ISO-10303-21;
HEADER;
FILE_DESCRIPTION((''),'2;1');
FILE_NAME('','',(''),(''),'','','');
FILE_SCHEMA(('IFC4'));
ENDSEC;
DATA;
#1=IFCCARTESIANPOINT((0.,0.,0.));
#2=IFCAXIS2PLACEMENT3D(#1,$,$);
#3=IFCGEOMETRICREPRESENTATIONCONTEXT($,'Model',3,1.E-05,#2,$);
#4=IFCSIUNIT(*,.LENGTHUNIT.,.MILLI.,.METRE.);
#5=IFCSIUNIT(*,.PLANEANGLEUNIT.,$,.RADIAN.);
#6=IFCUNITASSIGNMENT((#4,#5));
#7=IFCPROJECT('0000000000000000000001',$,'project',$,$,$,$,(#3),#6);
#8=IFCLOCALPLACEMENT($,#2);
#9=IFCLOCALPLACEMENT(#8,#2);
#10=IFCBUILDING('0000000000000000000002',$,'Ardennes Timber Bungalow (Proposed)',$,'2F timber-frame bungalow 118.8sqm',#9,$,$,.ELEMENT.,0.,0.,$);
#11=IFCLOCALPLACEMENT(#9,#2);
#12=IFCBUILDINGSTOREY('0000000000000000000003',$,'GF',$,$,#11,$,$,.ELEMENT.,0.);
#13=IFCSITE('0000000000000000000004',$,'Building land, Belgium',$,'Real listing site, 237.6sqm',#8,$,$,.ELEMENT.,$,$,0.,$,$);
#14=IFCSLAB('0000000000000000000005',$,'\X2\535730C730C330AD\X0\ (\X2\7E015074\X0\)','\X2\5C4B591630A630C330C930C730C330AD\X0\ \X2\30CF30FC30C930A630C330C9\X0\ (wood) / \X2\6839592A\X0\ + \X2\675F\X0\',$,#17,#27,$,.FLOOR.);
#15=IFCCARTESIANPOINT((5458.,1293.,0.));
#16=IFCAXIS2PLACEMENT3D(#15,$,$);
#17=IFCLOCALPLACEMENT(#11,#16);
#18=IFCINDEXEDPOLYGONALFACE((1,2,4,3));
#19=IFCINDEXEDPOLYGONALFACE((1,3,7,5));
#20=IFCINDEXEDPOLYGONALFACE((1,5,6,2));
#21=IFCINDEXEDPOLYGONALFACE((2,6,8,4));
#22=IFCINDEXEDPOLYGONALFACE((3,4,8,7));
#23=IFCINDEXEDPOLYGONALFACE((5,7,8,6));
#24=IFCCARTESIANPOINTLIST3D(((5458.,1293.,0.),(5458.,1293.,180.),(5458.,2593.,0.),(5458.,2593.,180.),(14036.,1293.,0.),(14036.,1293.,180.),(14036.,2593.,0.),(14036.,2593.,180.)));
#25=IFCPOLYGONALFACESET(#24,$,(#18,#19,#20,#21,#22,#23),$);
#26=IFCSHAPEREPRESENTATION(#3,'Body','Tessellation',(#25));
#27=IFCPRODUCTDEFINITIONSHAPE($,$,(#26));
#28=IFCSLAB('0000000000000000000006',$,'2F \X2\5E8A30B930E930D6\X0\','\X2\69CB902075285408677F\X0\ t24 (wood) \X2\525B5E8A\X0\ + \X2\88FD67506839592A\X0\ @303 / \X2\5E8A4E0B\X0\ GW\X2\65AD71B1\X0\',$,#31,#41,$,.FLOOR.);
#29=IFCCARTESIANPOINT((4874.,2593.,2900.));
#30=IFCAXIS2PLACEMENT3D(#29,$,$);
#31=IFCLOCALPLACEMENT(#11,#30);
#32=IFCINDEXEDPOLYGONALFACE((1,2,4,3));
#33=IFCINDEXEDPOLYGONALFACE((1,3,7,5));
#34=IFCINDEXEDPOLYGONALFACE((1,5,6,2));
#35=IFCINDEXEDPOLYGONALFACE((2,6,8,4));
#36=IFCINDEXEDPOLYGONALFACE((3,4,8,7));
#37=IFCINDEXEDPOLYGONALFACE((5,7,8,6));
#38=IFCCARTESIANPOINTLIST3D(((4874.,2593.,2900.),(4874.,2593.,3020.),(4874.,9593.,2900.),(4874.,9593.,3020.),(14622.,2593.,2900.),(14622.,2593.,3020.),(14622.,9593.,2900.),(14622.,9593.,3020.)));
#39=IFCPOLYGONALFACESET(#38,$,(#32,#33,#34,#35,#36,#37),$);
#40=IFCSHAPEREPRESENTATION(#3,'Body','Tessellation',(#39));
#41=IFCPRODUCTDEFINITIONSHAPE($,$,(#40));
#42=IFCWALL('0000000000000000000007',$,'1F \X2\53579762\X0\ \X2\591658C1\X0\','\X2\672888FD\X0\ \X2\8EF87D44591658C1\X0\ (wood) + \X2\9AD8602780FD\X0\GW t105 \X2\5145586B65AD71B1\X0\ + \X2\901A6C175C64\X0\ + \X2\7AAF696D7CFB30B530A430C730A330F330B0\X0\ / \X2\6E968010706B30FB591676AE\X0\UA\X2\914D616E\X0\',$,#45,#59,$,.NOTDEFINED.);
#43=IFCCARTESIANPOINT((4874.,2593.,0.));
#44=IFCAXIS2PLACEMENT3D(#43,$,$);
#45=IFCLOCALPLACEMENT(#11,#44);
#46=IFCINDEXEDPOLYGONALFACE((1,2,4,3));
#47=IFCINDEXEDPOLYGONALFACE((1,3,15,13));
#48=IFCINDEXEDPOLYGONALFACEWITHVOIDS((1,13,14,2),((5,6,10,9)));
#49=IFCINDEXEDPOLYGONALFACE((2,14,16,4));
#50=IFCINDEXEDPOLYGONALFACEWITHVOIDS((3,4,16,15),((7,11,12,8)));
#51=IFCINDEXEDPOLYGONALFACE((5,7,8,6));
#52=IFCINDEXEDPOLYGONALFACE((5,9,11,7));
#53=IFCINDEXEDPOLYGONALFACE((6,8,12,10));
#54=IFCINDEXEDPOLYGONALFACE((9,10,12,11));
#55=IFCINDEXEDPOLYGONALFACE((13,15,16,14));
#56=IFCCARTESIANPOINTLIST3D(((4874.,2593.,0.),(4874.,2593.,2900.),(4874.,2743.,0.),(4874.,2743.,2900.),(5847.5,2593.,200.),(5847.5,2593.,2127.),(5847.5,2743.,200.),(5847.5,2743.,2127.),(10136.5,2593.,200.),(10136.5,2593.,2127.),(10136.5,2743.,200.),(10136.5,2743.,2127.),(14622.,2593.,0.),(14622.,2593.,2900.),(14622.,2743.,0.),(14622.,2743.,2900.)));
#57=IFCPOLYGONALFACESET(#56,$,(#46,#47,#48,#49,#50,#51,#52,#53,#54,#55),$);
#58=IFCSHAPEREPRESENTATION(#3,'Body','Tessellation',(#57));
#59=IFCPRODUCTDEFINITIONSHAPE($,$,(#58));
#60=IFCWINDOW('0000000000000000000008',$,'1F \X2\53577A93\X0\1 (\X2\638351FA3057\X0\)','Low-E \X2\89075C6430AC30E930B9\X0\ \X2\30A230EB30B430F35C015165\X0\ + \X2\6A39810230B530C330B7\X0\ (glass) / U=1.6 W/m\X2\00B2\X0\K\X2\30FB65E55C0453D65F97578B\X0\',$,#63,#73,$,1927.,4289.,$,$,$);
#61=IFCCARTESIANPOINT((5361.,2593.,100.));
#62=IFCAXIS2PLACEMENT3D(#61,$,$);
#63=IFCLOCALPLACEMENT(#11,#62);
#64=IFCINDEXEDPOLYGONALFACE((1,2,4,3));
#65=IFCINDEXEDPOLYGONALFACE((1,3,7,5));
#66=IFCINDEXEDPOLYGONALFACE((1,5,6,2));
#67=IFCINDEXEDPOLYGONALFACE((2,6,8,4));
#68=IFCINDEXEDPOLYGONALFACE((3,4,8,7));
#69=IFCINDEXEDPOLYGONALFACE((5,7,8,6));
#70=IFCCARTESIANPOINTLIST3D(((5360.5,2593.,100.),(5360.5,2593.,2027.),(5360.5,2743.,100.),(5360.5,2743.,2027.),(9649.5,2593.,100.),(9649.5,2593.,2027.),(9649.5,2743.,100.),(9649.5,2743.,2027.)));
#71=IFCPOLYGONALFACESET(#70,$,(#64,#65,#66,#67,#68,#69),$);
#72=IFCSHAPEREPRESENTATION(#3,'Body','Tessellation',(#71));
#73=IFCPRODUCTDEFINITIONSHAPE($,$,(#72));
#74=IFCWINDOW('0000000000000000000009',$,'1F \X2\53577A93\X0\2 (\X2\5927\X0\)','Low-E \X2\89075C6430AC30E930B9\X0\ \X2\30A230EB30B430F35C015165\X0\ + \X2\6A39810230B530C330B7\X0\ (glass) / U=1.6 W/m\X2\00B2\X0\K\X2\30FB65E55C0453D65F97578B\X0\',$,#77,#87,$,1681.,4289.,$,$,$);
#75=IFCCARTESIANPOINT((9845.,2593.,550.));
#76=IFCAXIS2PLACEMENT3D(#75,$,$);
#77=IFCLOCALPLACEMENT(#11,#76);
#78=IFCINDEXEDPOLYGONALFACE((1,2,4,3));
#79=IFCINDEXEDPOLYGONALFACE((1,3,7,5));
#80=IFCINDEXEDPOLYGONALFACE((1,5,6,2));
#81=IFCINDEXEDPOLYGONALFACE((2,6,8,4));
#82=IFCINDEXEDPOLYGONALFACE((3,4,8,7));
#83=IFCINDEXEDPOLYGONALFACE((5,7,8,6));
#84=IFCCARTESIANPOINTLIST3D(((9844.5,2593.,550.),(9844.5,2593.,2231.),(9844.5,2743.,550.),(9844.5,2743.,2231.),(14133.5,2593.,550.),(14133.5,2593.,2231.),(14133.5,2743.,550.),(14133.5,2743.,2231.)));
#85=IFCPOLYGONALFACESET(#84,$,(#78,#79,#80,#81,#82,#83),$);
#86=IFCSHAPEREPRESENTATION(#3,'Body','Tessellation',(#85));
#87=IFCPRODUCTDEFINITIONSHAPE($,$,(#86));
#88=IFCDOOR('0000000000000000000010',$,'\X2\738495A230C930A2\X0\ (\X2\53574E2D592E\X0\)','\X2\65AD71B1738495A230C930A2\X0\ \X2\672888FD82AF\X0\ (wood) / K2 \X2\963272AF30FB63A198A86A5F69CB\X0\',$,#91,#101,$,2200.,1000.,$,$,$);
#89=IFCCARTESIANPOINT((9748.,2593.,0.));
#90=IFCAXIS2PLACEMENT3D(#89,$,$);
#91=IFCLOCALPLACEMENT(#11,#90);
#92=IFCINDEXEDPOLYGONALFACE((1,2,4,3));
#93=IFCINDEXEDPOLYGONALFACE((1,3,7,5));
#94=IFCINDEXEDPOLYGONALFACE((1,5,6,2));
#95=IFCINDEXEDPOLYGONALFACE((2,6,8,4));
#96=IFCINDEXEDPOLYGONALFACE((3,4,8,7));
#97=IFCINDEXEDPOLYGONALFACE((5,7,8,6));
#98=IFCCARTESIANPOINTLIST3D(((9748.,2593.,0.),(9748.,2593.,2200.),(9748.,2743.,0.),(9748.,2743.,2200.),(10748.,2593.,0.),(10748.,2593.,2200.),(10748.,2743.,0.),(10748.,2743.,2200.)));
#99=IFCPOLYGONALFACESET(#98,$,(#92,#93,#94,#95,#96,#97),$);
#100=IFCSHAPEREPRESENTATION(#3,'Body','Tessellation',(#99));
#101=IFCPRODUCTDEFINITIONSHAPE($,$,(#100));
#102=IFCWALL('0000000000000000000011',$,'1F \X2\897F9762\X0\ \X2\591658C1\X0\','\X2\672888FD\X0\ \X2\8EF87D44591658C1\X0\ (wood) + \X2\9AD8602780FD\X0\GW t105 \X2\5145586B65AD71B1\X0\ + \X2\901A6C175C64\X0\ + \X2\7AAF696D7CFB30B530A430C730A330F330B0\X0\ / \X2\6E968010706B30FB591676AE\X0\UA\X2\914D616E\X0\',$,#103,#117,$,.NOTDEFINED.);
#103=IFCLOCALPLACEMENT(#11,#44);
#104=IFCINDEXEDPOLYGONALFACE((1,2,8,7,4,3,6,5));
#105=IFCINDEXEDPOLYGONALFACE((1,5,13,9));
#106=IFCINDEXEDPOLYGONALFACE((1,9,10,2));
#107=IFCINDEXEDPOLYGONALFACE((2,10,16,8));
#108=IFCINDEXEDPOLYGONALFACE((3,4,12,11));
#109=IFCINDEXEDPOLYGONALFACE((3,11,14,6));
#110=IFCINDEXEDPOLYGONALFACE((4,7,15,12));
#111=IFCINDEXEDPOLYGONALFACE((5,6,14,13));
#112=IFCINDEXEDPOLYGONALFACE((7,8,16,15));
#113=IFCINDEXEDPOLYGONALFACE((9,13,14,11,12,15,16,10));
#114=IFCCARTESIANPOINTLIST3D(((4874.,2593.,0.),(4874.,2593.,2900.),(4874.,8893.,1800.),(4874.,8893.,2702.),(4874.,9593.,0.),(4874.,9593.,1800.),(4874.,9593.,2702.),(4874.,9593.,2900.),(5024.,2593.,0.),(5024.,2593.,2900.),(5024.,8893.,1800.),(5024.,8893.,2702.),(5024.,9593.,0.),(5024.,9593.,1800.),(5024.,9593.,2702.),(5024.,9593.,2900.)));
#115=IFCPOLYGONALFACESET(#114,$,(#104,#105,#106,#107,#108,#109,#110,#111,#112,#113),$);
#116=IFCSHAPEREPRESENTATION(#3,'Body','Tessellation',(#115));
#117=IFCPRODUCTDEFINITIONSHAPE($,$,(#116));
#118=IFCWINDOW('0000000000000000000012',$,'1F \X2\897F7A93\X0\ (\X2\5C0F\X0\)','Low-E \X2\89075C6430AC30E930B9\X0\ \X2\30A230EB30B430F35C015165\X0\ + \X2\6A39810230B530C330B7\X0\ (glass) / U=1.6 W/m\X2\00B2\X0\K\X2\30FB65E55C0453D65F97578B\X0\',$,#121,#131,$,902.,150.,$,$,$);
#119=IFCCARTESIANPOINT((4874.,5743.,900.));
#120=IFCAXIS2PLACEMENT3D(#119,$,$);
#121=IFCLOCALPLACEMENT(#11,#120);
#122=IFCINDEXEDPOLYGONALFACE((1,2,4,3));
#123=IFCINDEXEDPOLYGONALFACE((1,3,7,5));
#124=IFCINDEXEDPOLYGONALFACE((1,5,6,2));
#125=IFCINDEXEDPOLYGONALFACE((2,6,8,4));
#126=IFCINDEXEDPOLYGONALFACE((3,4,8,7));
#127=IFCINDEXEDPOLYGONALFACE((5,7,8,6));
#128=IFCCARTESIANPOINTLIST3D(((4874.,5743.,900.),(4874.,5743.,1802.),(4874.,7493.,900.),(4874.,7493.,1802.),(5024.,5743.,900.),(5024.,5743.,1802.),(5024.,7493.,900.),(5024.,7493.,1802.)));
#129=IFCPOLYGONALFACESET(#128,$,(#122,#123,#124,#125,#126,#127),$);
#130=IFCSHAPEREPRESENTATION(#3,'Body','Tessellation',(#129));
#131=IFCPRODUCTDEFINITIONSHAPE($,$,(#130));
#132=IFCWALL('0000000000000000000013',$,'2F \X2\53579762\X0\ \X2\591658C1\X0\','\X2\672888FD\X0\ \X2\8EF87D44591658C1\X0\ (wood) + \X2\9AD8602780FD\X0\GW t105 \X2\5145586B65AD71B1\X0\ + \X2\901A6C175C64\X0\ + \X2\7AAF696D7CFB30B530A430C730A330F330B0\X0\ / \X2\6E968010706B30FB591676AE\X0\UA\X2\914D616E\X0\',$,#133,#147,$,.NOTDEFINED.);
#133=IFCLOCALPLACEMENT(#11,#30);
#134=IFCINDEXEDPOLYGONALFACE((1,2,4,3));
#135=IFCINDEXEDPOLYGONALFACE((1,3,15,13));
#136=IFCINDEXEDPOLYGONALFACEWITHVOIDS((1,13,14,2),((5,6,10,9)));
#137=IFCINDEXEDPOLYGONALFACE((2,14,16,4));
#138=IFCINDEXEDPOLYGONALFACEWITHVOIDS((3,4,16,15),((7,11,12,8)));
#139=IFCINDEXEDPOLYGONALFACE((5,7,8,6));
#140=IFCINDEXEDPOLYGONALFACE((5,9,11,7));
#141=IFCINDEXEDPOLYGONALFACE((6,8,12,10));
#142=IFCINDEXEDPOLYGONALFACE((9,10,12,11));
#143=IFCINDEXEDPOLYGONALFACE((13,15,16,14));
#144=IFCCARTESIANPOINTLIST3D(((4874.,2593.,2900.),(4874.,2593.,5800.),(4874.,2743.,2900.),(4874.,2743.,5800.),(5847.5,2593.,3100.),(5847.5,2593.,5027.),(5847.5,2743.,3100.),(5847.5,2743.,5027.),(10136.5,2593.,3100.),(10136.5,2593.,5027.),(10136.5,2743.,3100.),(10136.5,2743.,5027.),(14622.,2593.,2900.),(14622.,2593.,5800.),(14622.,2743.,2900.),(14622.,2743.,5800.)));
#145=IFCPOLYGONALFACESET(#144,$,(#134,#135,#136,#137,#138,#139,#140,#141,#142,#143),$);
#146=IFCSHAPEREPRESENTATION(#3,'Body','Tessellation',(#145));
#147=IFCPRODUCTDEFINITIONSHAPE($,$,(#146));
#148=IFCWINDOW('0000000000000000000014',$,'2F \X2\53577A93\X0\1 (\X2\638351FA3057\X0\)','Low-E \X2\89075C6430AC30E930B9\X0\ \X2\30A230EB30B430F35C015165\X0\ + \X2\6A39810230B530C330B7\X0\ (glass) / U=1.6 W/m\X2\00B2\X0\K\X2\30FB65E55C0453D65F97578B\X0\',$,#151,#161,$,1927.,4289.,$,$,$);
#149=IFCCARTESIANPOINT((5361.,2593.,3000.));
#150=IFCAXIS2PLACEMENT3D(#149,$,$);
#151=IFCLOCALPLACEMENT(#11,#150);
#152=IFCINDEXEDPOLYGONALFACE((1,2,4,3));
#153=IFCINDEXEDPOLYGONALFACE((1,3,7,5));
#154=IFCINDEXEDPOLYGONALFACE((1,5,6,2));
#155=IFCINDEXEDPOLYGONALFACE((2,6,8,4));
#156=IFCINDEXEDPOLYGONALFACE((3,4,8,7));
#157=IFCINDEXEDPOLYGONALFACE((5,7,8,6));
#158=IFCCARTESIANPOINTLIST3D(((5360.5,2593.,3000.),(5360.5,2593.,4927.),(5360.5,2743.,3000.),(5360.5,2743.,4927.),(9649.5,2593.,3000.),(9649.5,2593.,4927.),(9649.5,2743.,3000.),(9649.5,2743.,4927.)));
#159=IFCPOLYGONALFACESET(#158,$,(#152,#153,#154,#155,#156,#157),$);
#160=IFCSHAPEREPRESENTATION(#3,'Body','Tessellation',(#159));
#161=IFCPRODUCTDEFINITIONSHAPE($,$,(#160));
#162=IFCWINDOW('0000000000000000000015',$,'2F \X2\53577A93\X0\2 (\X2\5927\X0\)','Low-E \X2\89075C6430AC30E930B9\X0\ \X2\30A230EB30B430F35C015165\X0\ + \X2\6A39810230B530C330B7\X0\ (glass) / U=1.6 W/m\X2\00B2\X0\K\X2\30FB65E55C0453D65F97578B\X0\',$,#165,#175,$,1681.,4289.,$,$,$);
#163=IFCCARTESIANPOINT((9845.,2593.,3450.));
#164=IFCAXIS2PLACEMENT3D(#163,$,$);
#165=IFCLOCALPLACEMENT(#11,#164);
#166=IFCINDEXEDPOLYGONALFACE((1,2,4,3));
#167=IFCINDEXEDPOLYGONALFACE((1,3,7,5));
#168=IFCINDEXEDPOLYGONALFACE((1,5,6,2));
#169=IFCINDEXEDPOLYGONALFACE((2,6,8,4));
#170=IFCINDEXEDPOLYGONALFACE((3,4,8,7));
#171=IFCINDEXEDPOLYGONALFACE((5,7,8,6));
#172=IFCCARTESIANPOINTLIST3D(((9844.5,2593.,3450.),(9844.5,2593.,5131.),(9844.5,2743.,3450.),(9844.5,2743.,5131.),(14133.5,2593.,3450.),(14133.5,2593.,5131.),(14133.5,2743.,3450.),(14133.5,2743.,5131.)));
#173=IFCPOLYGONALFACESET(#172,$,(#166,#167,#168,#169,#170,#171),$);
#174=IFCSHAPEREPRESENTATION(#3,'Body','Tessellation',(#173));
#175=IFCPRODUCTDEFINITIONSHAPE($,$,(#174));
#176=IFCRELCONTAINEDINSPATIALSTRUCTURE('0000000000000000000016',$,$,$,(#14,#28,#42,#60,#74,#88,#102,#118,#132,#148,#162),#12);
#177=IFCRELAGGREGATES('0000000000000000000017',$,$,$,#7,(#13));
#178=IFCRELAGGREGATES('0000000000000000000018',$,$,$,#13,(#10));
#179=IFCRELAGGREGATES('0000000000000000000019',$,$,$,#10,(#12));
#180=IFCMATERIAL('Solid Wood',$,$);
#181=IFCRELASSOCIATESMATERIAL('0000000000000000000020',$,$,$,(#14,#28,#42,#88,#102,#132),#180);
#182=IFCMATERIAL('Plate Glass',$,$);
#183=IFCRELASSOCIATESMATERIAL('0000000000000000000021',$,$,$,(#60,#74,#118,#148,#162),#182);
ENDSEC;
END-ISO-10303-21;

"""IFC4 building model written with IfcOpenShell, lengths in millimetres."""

from ifc_helpers import new_model, si_unit, frame, frame_2d, origin, place, context, project, spatial, rectangle, extrude, material, element, fill, save


model = new_model("IFC4")

# Units and contexts
model_context = context("Model", 3, precision=1e-05, world=origin())
ifc_project = project(units=[si_unit("LENGTHUNIT", "METRE", prefix="MILLI"), si_unit("PLANEANGLEUNIT", "RADIAN")], contexts=[model_context])

# Site, building, storey
site_placement = place(None, origin())
site = spatial("IfcSite", under=ifc_project, at=site_placement, Name="Building land, Belgium", ObjectType="Real listing site, 237.6sqm", CompositionType="ELEMENT", RefElevation=0.0)
building_placement = place(site_placement, origin())
building = spatial("IfcBuilding", under=site, at=building_placement, Name="Ardennes Timber Bungalow (Proposed)", ObjectType="2F timber-frame bungalow 118.8sqm", CompositionType="ELEMENT", ElevationOfRefHeight=0.0, ElevationOfTerrain=0.0)
storey_placement = place(building_placement, origin())
storey = spatial("IfcBuildingStorey", under=building, at=storey_placement, Name="GF", CompositionType="ELEMENT", Elevation=0.0)

# Slabs
ifc_material_1 = material(Name="Solid Wood")
slab_1_placement = place(storey_placement, frame((5458.0, 1293.0, 0.0)))
element("IfcSlab", 1, at=slab_1_placement, inside=storey, material=ifc_material_1, Name="南デッキ (縁側)", Description="屋外ウッドデッキ ハードウッド (wood) / 根太 + 束", PredefinedType="FLOOR", context=model_context, shape_type="SweptSolid", body=[
    extrude(rectangle(XDim=8578.0, YDim=1300.0, at=frame_2d((4289.0, 650.0))), frame((5458.0, 1293.0, 0.0)), (0.0, 0.0, 1.0), 180.0),
])
slab_2_placement = place(storey_placement, frame((4874.0, 2593.0, 2900.0)))
element("IfcSlab", 2, at=slab_2_placement, inside=storey, material=ifc_material_1, Name="2F 床スラブ", Description="構造用合板 t24 (wood) 剛床 + 製材根太 @303 / 床下 GW断熱", PredefinedType="FLOOR", context=model_context, shape_type="SweptSolid", body=[
    extrude(rectangle(XDim=9748.0, YDim=7000.0, at=frame_2d((4874.0, 3500.0))), frame((4874.0, 2593.0, 2900.0)), (0.0, 0.0, 1.0), 120.0),
])

# Wall, openings, windows, door
wall_1_placement = place(storey_placement, frame((4874.0, 2593.0, 0.0)))
wall_1 = element("IfcWall", 3, at=wall_1_placement, inside=storey, material=ifc_material_1, Name="1F 南面 外壁", Description="木製 軸組外壁 (wood) + 高性能GW t105 充填断熱 + 通気層 + 窯業系サイディング / 準耐火・外皮UA配慮", PredefinedType="NOTDEFINED", context=model_context, shape_type="SweptSolid", body=[
    extrude(rectangle(XDim=9748.0, YDim=150.0, at=frame_2d((4874.0, 75.0))), frame((4874.0, 2593.0, 0.0)), (0.0, 0.0, 1.0), 2900.0),
])
opening_1_placement = place(storey_placement, frame((5361.0, 2593.0, 100.0)))
opening_1 = element("IfcOpeningElement", 4, at=opening_1_placement, cuts=wall_1, PredefinedType="NOTDEFINED", context=model_context, shape_type="SweptSolid", body=[
    extrude(rectangle(XDim=4289.0, YDim=150.0, at=frame_2d((2144.0, 75.0))), frame((5361.0, 2593.0, 100.0)), (0.0, 0.0, 1.0), 1927.0),
])
opening_2_placement = place(storey_placement, frame((9845.0, 2593.0, 550.0)))
opening_2 = element("IfcOpeningElement", 5, at=opening_2_placement, cuts=wall_1, PredefinedType="NOTDEFINED", context=model_context, shape_type="SweptSolid", body=[
    extrude(rectangle(XDim=4289.0, YDim=150.0, at=frame_2d((2144.0, 75.0))), frame((9845.0, 2593.0, 550.0)), (0.0, 0.0, 1.0), 1681.0),
])
opening_3_placement = place(storey_placement, frame((9748.0, 2593.0, 0.0)))
opening_3 = element("IfcOpeningElement", 6, at=opening_3_placement, cuts=wall_1, PredefinedType="NOTDEFINED", context=model_context, shape_type="SweptSolid", body=[
    extrude(rectangle(XDim=1000.0, YDim=150.0, at=frame_2d((500.0, 75.0))), frame((9748.0, 2593.0, 0.0)), (0.0, 0.0, 1.0), 2200.0),
])
ifc_material_2 = material(Name="Plate Glass")
window_1_placement = place(storey_placement, frame((5361.0, 2593.0, 100.0)))
window_1 = element("IfcWindow", 7, at=window_1_placement, inside=storey, material=ifc_material_2, Name="1F 南窓1 (掃出し)", Description="Low-E 複層ガラス アルゴン封入 + 樹脂サッシ (glass) / U=1.6 W/m²K・日射取得型", OverallHeight=1927.0, OverallWidth=4289.0, context=model_context, shape_type="SweptSolid", body=[
    extrude(rectangle(XDim=4289.0, YDim=150.0, at=frame_2d((2144.0, 75.0))), frame((5361.0, 2593.0, 100.0)), (0.0, 0.0, 1.0), 1927.0),
])
fill(opening_1, window_1)
window_2_placement = place(storey_placement, frame((9845.0, 2593.0, 550.0)))
window_2 = element("IfcWindow", 8, at=window_2_placement, inside=storey, material=ifc_material_2, Name="1F 南窓2 (大)", Description="Low-E 複層ガラス アルゴン封入 + 樹脂サッシ (glass) / U=1.6 W/m²K・日射取得型", OverallHeight=1681.0, OverallWidth=4289.0, context=model_context, shape_type="SweptSolid", body=[
    extrude(rectangle(XDim=4289.0, YDim=150.0, at=frame_2d((2144.0, 75.0))), frame((9845.0, 2593.0, 550.0)), (0.0, 0.0, 1.0), 1681.0),
])
fill(opening_2, window_2)
door_placement = place(storey_placement, frame((9748.0, 2593.0, 0.0)))
door = element("IfcDoor", 9, at=door_placement, inside=storey, material=ifc_material_1, Name="玄関ドア (南中央)", Description="断熱玄関ドア 木製芯 (wood) / K2 防犯・採風機構", OverallHeight=2200.0, OverallWidth=1000.0, context=model_context, shape_type="SweptSolid", body=[
    extrude(rectangle(XDim=1000.0, YDim=150.0, at=frame_2d((500.0, 75.0))), frame((9748.0, 2593.0, 0.0)), (0.0, 0.0, 1.0), 2200.0),
])
fill(opening_3, door)

# Wall, opening, window
wall_2_placement = place(storey_placement, frame((4874.0, 2593.0, 0.0)))
wall_2 = element("IfcWall", 10, at=wall_2_placement, inside=storey, material=ifc_material_1, Name="1F 西面 外壁", Description="木製 軸組外壁 (wood) + 高性能GW t105 充填断熱 + 通気層 + 窯業系サイディング / 準耐火・外皮UA配慮", PredefinedType="NOTDEFINED", context=model_context, shape_type="SweptSolid", body=[
    extrude(rectangle(XDim=150.0, YDim=7000.0, at=frame_2d((75.0, 3500.0))), frame((4874.0, 2593.0, 0.0)), (0.0, 0.0, 1.0), 2900.0),
])
opening_4_placement = place(storey_placement, frame((4874.0, 5743.0, 900.0)))
opening_4 = element("IfcOpeningElement", 11, at=opening_4_placement, cuts=wall_2, PredefinedType="NOTDEFINED", context=model_context, shape_type="SweptSolid", body=[
    extrude(rectangle(XDim=150.0, YDim=1750.0, at=frame_2d((75.0, 875.0))), frame((4874.0, 5743.0, 900.0)), (0.0, 0.0, 1.0), 902.0),
])
window_3_placement = place(storey_placement, frame((4874.0, 5743.0, 900.0)))
window_3 = element("IfcWindow", 12, at=window_3_placement, inside=storey, material=ifc_material_2, Name="1F 西窓 (小)", Description="Low-E 複層ガラス アルゴン封入 + 樹脂サッシ (glass) / U=1.6 W/m²K・日射取得型", OverallHeight=902.0, OverallWidth=150.0, context=model_context, shape_type="SweptSolid", body=[
    extrude(rectangle(XDim=150.0, YDim=1750.0, at=frame_2d((75.0, 875.0))), frame((4874.0, 5743.0, 900.0)), (0.0, 0.0, 1.0), 902.0),
])
fill(opening_4, window_3)

# Wall, openings, windows
wall_3_placement = place(storey_placement, frame((4874.0, 2593.0, 2900.0)))
wall_3 = element("IfcWall", 13, at=wall_3_placement, inside=storey, material=ifc_material_1, Name="2F 南面 外壁", Description="木製 軸組外壁 (wood) + 高性能GW t105 充填断熱 + 通気層 + 窯業系サイディング / 準耐火・外皮UA配慮", PredefinedType="NOTDEFINED", context=model_context, shape_type="SweptSolid", body=[
    extrude(rectangle(XDim=9748.0, YDim=150.0, at=frame_2d((4874.0, 75.0))), frame((4874.0, 2593.0, 2900.0)), (0.0, 0.0, 1.0), 2900.0),
])
opening_5_placement = place(storey_placement, frame((5361.0, 2593.0, 3000.0)))
opening_5 = element("IfcOpeningElement", 14, at=opening_5_placement, cuts=wall_3, PredefinedType="NOTDEFINED", context=model_context, shape_type="SweptSolid", body=[
    extrude(rectangle(XDim=4289.0, YDim=150.0, at=frame_2d((2144.0, 75.0))), frame((5361.0, 2593.0, 3000.0)), (0.0, 0.0, 1.0), 1927.0),
])
opening_6_placement = place(storey_placement, frame((9845.0, 2593.0, 3450.0)))
opening_6 = element("IfcOpeningElement", 15, at=opening_6_placement, cuts=wall_3, PredefinedType="NOTDEFINED", context=model_context, shape_type="SweptSolid", body=[
    extrude(rectangle(XDim=4289.0, YDim=150.0, at=frame_2d((2144.0, 75.0))), frame((9845.0, 2593.0, 3450.0)), (0.0, 0.0, 1.0), 1681.0),
])
window_4_placement = place(storey_placement, frame((5361.0, 2593.0, 3000.0)))
window_4 = element("IfcWindow", 16, at=window_4_placement, inside=storey, material=ifc_material_2, Name="2F 南窓1 (掃出し)", Description="Low-E 複層ガラス アルゴン封入 + 樹脂サッシ (glass) / U=1.6 W/m²K・日射取得型", OverallHeight=1927.0, OverallWidth=4289.0, context=model_context, shape_type="SweptSolid", body=[
    extrude(rectangle(XDim=4289.0, YDim=150.0, at=frame_2d((2144.0, 75.0))), frame((5361.0, 2593.0, 3000.0)), (0.0, 0.0, 1.0), 1927.0),
])
fill(opening_5, window_4)
window_5_placement = place(storey_placement, frame((9845.0, 2593.0, 3450.0)))
window_5 = element("IfcWindow", 17, at=window_5_placement, inside=storey, material=ifc_material_2, Name="2F 南窓2 (大)", Description="Low-E 複層ガラス アルゴン封入 + 樹脂サッシ (glass) / U=1.6 W/m²K・日射取得型", OverallHeight=1681.0, OverallWidth=4289.0, context=model_context, shape_type="SweptSolid", body=[
    extrude(rectangle(XDim=4289.0, YDim=150.0, at=frame_2d((2144.0, 75.0))), frame((9845.0, 2593.0, 3450.0)), (0.0, 0.0, 1.0), 1681.0),
])
fill(opening_6, window_5)

save(model, "model.ifc")
